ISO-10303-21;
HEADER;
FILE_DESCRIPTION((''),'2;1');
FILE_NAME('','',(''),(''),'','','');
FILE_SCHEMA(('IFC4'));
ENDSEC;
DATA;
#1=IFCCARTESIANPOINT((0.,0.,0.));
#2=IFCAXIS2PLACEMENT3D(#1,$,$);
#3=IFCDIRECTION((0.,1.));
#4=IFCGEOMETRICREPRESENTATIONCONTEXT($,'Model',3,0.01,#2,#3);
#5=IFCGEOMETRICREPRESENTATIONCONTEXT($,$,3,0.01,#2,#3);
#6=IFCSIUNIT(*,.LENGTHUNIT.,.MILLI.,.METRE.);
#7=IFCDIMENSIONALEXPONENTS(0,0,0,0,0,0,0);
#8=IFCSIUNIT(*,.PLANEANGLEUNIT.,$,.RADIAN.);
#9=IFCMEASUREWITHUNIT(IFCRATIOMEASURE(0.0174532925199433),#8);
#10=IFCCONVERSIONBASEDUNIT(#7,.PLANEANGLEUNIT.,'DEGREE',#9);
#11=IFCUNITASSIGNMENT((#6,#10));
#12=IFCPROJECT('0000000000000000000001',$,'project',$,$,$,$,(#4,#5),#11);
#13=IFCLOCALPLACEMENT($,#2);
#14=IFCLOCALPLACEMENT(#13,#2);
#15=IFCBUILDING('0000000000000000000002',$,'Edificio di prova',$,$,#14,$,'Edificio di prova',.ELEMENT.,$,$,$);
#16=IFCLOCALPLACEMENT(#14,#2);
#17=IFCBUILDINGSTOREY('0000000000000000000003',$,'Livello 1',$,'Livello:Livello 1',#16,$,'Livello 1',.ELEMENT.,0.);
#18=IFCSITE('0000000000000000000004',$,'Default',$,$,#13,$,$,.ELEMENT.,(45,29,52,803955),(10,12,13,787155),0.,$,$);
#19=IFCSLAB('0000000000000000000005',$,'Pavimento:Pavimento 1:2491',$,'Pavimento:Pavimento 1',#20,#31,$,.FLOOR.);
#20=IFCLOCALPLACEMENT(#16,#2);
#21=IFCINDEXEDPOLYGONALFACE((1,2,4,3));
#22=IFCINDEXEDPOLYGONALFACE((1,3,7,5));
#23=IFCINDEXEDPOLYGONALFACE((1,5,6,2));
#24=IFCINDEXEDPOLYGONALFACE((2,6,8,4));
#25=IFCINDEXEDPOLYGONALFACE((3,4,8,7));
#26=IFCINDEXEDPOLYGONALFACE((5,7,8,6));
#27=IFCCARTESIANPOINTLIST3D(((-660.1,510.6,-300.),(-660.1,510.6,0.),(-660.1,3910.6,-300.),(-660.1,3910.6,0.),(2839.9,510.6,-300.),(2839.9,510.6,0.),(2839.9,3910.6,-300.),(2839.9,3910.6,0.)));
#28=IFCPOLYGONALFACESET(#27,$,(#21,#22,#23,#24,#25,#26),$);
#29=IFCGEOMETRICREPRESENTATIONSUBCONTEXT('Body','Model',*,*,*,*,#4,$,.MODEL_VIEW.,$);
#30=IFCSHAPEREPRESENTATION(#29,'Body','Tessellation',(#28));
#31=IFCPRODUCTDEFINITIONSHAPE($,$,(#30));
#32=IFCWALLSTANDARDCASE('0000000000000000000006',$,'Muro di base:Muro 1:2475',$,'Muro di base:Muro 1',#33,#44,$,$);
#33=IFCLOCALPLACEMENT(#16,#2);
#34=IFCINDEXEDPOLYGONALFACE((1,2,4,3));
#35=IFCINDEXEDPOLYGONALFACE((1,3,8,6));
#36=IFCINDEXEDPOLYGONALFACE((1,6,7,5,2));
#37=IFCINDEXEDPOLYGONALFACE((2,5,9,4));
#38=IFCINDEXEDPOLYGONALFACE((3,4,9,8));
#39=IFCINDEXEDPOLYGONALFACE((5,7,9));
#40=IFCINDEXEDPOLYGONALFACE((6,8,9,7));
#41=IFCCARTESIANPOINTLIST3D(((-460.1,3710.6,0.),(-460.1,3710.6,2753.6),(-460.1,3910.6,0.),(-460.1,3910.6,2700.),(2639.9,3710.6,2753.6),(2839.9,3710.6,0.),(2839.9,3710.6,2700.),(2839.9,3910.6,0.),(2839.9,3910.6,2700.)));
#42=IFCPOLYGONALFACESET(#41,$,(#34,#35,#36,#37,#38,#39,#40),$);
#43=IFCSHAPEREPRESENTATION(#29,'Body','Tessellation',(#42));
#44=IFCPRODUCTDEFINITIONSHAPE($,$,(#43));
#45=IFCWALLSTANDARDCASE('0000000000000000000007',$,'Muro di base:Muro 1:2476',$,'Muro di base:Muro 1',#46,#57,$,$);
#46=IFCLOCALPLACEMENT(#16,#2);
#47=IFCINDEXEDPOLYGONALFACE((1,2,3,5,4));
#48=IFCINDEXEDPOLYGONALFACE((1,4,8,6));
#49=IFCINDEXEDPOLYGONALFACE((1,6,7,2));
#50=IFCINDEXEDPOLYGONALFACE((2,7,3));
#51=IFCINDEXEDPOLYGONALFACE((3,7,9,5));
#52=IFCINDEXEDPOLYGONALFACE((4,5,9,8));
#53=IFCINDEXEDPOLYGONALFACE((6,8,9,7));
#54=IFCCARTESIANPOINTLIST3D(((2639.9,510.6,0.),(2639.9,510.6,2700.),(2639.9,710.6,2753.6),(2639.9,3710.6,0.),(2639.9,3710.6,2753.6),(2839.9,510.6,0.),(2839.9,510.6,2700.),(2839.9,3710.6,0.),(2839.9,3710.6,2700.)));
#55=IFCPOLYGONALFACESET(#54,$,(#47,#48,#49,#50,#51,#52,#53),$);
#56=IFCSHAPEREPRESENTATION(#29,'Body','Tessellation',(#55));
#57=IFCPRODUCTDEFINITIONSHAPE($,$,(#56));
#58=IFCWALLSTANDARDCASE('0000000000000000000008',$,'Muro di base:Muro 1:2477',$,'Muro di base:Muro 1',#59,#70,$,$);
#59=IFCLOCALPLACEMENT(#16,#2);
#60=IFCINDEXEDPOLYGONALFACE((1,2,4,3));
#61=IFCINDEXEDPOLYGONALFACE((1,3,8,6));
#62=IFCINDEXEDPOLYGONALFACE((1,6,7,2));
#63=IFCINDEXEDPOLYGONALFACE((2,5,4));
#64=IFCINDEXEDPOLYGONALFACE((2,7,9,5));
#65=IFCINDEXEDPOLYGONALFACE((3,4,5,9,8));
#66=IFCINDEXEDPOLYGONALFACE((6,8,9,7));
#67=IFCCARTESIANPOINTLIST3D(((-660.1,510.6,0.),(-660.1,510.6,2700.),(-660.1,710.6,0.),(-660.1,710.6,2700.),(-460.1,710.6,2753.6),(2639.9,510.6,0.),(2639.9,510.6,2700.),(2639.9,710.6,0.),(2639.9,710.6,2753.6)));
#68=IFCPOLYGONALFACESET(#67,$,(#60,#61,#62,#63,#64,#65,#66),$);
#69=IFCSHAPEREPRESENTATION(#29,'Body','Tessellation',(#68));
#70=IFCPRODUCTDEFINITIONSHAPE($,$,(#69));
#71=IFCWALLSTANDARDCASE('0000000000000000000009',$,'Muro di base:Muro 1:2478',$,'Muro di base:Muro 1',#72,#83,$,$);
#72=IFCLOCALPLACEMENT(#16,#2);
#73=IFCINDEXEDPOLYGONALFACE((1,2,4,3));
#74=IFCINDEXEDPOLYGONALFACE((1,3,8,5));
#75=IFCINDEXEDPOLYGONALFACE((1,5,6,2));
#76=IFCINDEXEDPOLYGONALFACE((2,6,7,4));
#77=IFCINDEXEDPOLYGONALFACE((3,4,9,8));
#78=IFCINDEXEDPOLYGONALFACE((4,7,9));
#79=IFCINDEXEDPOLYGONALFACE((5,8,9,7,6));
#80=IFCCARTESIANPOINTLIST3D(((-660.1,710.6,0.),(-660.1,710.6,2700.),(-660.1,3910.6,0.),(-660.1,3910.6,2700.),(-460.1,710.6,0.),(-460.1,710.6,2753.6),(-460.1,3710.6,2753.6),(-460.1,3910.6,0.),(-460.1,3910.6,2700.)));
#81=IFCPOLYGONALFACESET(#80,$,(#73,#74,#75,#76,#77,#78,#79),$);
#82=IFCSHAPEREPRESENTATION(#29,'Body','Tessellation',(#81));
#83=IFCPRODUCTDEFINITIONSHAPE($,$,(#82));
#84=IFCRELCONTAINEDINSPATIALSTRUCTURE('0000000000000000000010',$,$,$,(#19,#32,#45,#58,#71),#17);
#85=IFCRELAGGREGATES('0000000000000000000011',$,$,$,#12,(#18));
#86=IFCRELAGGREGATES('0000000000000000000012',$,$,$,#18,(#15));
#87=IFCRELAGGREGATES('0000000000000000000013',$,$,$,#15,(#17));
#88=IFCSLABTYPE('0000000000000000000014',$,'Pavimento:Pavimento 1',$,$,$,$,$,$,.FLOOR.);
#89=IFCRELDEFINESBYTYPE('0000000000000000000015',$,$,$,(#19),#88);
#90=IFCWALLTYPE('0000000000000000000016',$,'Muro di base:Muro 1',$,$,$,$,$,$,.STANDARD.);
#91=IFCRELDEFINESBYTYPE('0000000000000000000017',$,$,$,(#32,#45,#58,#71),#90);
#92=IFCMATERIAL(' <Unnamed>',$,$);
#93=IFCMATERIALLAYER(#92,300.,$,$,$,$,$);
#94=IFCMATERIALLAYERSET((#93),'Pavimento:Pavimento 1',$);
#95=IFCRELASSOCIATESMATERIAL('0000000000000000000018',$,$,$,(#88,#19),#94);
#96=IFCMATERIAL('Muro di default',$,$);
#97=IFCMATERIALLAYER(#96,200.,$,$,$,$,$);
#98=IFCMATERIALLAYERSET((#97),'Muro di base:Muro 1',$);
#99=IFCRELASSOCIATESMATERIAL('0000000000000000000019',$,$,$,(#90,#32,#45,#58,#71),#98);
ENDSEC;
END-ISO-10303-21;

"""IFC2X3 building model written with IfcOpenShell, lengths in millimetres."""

from ifc_helpers import new_model, entity, si_unit, converted_unit, direction, frame, frame_2d, origin, origin_2d_with_axis, place, context, subcontext, project, spatial, polyline, rectangle, extrude, clip, bounded_halfspace, material, layer, layer_set, layer_usage, type_object, element, save


model = new_model("IFC2X3")

# Units and contexts
model_context = context("Model", 3, precision=0.01, world=origin(), true_north=direction((0.0, 1.0)))
context_of_model = context(None, 3, precision=0.01, world=origin(), true_north=direction((0.0, 1.0)))
body_context = subcontext(model_context, "Body", "Model", "MODEL_VIEW")
ifc_project = project(units=[si_unit("LENGTHUNIT", "METRE", prefix="MILLI"), converted_unit("PLANEANGLEUNIT", "DEGREE", entity("IfcRatioMeasure", 0.0174532925199433), si_unit("PLANEANGLEUNIT", "RADIAN"), dimensions=[0, 0, 0, 0, 0, 0, 0])], contexts=[model_context, context_of_model])

# Site, building, storey
site_placement = place(None, origin())
site = spatial("IfcSite", under=ifc_project, at=site_placement, Name="Default", CompositionType="ELEMENT", RefLatitude=(45, 29, 52, 803955), RefLongitude=(10, 12, 13, 787155), RefElevation=0.0)
building_placement = place(site_placement, origin())
building = spatial("IfcBuilding", under=site, at=building_placement, Name="Edificio di prova", LongName="Edificio di prova", CompositionType="ELEMENT")
storey_placement = place(building_placement, origin())
storey = spatial("IfcBuildingStorey", under=building, at=storey_placement, Name="Livello 1", ObjectType="Livello:Livello 1", LongName="Livello 1", CompositionType="ELEMENT", Elevation=0.0)

# Slab
ifc_material_1 = material(Name=" <Unnamed>")
ifc_layer_1 = layer(ifc_material_1, 300.0)
ifc_layer_set_1 = layer_set([ifc_layer_1], Name="Pavimento:Pavimento 1")
ifc_layer_usage_1 = layer_usage(ifc_layer_set_1, "AXIS3", "POSITIVE", 0.0)
slab_type = type_object("IfcSlabType", Name="Pavimento:Pavimento 1", PredefinedType="FLOOR", material=ifc_layer_set_1)
slab_placement = place(storey_placement, origin())
element("IfcSlab", 1, at=slab_placement, inside=storey, type_object=slab_type, material=ifc_layer_usage_1, Name="Pavimento:Pavimento 1:2491", ObjectType="Pavimento:Pavimento 1", PredefinedType="FLOOR", context=body_context, shape_type="SweptSolid", body=[
    extrude(rectangle(XDim=3400.0, YDim=3500.0, at=origin_2d_with_axis()), frame((1089.9, 2210.6, 0.0), z_axis=(0.0, 0.0, -1.0), x_axis=(0.0, 1.0, 0.0)), (0.0, 0.0, 1.0), 300.0),
])

# Walls
ifc_material_2 = material(Name="Muro di default")
ifc_layer_2 = layer(ifc_material_2, 200.0)
ifc_layer_set_2 = layer_set([ifc_layer_2], Name="Muro di base:Muro 1")
ifc_layer_usage_2 = layer_usage(ifc_layer_set_2, "AXIS2", "NEGATIVE", 100.0)
wall_type = type_object("IfcWallType", Name="Muro di base:Muro 1", PredefinedType="STANDARD", material=ifc_layer_set_2)
wall_1_placement = place(storey_placement, frame((2839.9, 3810.6, 0.0), z_axis=(0.0, 0.0, 1.0), x_axis=(-1.0, 0.0, 0.0)))
element("IfcWallStandardCase", 2, at=wall_1_placement, inside=storey, type_object=wall_type, material=ifc_layer_usage_2, Name="Muro di base:Muro 1:2475", ObjectType="Muro di base:Muro 1", context=body_context, shape_type="Clipping", body=[
    clip(clip(extrude(rectangle(XDim=3300.0, YDim=200.0, at=frame_2d((1650.0, 0.0), x_axis=(-1.0, 0.0))), origin(), (0.0, 0.0, 1.0), 2753.6), bounded_halfspace(frame((0.0, -100.0, 2700.0), z_axis=(0.0, -0.258819, 0.965926), x_axis=(1.0, 0.0, 0.0)), False, frame((0.0, -100.0, 2700.0)), polyline([(0.0, 0.0), (3300.0, 0.0), (3300.0, 200.0), (200.0, 200.0), (0.0, 0.0)]))), bounded_halfspace(frame((200.0, 100.0, 2753.6), z_axis=(-0.258819, 0.0, 0.965926), x_axis=(0.0, -1.0, 0.0)), False, frame((200.0, 100.0, 2753.6)), polyline([(0.0, 0.0), (-200.0, 0.0), (-200.0, -200.0), (0.0, 0.0)]))),
])
ifc_layer_usage_3 = layer_usage(ifc_layer_set_2, "AXIS2", "NEGATIVE", 100.0)
wall_2_placement = place(storey_placement, frame((2739.9, 510.6, 0.0), z_axis=(0.0, 0.0, 1.0), x_axis=(0.0, 1.0, 0.0)))
element("IfcWallStandardCase", 3, at=wall_2_placement, inside=storey, type_object=wall_type, material=ifc_layer_usage_3, Name="Muro di base:Muro 1:2476", ObjectType="Muro di base:Muro 1", context=body_context, shape_type="Clipping", body=[
    clip(clip(extrude(rectangle(XDim=3200.0, YDim=200.0, at=frame_2d((1600.0, 0.0), x_axis=(-1.0, 0.0))), origin(), (0.0, 0.0, 1.0), 2753.6), bounded_halfspace(frame((0.0, -100.0, 2700.0), z_axis=(0.0, -0.258819, 0.965926), x_axis=(1.0, 0.0, 0.0)), False, frame((0.0, -100.0, 2700.0)), polyline([(0.0, 0.0), (3200.0, 0.0), (3200.0, 200.0), (200.0, 200.0), (0.0, 0.0)]))), bounded_halfspace(frame((200.0, 100.0, 2753.6), z_axis=(-0.258819, 0.0, 0.965926), x_axis=(0.0, -1.0, 0.0)), False, frame((200.0, 100.0, 2753.6)), polyline([(0.0, 0.0), (-200.0, 0.0), (-200.0, -200.0), (0.0, 0.0)]))),
])
ifc_layer_usage_4 = layer_usage(ifc_layer_set_2, "AXIS2", "NEGATIVE", 100.0)
wall_3_placement = place(storey_placement, frame((-660.1, 610.6, 0.0)))
element("IfcWallStandardCase", 4, at=wall_3_placement, inside=storey, type_object=wall_type, material=ifc_layer_usage_4, Name="Muro di base:Muro 1:2477", ObjectType="Muro di base:Muro 1", context=body_context, shape_type="Clipping", body=[
    clip(clip(extrude(rectangle(XDim=3300.0, YDim=200.0, at=frame_2d((1650.0, 0.0), x_axis=(-1.0, 0.0))), origin(), (0.0, 0.0, 1.0), 2753.6), bounded_halfspace(frame((0.0, -100.0, 2700.0), z_axis=(0.0, -0.258819, 0.965926), x_axis=(1.0, 0.0, 0.0)), False, frame((0.0, -100.0, 2700.0)), polyline([(0.0, 0.0), (3300.0, 0.0), (3300.0, 200.0), (200.0, 200.0), (0.0, 0.0)]))), bounded_halfspace(frame((200.0, 100.0, 2753.6), z_axis=(-0.258819, 0.0, 0.965926), x_axis=(0.0, -1.0, 0.0)), False, frame((200.0, 100.0, 2753.6)), polyline([(0.0, 0.0), (-200.0, 0.0), (-200.0, -200.0), (0.0, 0.0)]))),
])
ifc_layer_usage_5 = layer_usage(ifc_layer_set_2, "AXIS2", "NEGATIVE", 100.0)
wall_4_placement = place(storey_placement, frame((-560.1, 3910.6, 0.0), z_axis=(0.0, 0.0, 1.0), x_axis=(0.0, -1.0, 0.0)))
element("IfcWallStandardCase", 5, at=wall_4_placement, inside=storey, type_object=wall_type, material=ifc_layer_usage_5, Name="Muro di base:Muro 1:2478", ObjectType="Muro di base:Muro 1", context=body_context, shape_type="Clipping", body=[
    clip(clip(extrude(rectangle(XDim=3200.0, YDim=200.0, at=frame_2d((1600.0, 0.0), x_axis=(-1.0, 0.0))), origin(), (0.0, 0.0, 1.0), 2753.6), bounded_halfspace(frame((200.0, 100.0, 2753.6), z_axis=(-0.258819, 0.0, 0.965926), x_axis=(0.0, -1.0, 0.0)), False, frame((200.0, 100.0, 2753.6)), polyline([(0.0, 0.0), (-200.0, 0.0), (-200.0, -200.0), (0.0, 0.0)]))), bounded_halfspace(frame((0.0, -100.0, 2700.0), z_axis=(0.0, -0.258819, 0.965926), x_axis=(1.0, 0.0, 0.0)), False, frame((0.0, -100.0, 2700.0)), polyline([(0.0, 0.0), (3200.0, 0.0), (3200.0, 200.0), (200.0, 200.0), (0.0, 0.0)]))),
])

save(model, "model.ifc")
